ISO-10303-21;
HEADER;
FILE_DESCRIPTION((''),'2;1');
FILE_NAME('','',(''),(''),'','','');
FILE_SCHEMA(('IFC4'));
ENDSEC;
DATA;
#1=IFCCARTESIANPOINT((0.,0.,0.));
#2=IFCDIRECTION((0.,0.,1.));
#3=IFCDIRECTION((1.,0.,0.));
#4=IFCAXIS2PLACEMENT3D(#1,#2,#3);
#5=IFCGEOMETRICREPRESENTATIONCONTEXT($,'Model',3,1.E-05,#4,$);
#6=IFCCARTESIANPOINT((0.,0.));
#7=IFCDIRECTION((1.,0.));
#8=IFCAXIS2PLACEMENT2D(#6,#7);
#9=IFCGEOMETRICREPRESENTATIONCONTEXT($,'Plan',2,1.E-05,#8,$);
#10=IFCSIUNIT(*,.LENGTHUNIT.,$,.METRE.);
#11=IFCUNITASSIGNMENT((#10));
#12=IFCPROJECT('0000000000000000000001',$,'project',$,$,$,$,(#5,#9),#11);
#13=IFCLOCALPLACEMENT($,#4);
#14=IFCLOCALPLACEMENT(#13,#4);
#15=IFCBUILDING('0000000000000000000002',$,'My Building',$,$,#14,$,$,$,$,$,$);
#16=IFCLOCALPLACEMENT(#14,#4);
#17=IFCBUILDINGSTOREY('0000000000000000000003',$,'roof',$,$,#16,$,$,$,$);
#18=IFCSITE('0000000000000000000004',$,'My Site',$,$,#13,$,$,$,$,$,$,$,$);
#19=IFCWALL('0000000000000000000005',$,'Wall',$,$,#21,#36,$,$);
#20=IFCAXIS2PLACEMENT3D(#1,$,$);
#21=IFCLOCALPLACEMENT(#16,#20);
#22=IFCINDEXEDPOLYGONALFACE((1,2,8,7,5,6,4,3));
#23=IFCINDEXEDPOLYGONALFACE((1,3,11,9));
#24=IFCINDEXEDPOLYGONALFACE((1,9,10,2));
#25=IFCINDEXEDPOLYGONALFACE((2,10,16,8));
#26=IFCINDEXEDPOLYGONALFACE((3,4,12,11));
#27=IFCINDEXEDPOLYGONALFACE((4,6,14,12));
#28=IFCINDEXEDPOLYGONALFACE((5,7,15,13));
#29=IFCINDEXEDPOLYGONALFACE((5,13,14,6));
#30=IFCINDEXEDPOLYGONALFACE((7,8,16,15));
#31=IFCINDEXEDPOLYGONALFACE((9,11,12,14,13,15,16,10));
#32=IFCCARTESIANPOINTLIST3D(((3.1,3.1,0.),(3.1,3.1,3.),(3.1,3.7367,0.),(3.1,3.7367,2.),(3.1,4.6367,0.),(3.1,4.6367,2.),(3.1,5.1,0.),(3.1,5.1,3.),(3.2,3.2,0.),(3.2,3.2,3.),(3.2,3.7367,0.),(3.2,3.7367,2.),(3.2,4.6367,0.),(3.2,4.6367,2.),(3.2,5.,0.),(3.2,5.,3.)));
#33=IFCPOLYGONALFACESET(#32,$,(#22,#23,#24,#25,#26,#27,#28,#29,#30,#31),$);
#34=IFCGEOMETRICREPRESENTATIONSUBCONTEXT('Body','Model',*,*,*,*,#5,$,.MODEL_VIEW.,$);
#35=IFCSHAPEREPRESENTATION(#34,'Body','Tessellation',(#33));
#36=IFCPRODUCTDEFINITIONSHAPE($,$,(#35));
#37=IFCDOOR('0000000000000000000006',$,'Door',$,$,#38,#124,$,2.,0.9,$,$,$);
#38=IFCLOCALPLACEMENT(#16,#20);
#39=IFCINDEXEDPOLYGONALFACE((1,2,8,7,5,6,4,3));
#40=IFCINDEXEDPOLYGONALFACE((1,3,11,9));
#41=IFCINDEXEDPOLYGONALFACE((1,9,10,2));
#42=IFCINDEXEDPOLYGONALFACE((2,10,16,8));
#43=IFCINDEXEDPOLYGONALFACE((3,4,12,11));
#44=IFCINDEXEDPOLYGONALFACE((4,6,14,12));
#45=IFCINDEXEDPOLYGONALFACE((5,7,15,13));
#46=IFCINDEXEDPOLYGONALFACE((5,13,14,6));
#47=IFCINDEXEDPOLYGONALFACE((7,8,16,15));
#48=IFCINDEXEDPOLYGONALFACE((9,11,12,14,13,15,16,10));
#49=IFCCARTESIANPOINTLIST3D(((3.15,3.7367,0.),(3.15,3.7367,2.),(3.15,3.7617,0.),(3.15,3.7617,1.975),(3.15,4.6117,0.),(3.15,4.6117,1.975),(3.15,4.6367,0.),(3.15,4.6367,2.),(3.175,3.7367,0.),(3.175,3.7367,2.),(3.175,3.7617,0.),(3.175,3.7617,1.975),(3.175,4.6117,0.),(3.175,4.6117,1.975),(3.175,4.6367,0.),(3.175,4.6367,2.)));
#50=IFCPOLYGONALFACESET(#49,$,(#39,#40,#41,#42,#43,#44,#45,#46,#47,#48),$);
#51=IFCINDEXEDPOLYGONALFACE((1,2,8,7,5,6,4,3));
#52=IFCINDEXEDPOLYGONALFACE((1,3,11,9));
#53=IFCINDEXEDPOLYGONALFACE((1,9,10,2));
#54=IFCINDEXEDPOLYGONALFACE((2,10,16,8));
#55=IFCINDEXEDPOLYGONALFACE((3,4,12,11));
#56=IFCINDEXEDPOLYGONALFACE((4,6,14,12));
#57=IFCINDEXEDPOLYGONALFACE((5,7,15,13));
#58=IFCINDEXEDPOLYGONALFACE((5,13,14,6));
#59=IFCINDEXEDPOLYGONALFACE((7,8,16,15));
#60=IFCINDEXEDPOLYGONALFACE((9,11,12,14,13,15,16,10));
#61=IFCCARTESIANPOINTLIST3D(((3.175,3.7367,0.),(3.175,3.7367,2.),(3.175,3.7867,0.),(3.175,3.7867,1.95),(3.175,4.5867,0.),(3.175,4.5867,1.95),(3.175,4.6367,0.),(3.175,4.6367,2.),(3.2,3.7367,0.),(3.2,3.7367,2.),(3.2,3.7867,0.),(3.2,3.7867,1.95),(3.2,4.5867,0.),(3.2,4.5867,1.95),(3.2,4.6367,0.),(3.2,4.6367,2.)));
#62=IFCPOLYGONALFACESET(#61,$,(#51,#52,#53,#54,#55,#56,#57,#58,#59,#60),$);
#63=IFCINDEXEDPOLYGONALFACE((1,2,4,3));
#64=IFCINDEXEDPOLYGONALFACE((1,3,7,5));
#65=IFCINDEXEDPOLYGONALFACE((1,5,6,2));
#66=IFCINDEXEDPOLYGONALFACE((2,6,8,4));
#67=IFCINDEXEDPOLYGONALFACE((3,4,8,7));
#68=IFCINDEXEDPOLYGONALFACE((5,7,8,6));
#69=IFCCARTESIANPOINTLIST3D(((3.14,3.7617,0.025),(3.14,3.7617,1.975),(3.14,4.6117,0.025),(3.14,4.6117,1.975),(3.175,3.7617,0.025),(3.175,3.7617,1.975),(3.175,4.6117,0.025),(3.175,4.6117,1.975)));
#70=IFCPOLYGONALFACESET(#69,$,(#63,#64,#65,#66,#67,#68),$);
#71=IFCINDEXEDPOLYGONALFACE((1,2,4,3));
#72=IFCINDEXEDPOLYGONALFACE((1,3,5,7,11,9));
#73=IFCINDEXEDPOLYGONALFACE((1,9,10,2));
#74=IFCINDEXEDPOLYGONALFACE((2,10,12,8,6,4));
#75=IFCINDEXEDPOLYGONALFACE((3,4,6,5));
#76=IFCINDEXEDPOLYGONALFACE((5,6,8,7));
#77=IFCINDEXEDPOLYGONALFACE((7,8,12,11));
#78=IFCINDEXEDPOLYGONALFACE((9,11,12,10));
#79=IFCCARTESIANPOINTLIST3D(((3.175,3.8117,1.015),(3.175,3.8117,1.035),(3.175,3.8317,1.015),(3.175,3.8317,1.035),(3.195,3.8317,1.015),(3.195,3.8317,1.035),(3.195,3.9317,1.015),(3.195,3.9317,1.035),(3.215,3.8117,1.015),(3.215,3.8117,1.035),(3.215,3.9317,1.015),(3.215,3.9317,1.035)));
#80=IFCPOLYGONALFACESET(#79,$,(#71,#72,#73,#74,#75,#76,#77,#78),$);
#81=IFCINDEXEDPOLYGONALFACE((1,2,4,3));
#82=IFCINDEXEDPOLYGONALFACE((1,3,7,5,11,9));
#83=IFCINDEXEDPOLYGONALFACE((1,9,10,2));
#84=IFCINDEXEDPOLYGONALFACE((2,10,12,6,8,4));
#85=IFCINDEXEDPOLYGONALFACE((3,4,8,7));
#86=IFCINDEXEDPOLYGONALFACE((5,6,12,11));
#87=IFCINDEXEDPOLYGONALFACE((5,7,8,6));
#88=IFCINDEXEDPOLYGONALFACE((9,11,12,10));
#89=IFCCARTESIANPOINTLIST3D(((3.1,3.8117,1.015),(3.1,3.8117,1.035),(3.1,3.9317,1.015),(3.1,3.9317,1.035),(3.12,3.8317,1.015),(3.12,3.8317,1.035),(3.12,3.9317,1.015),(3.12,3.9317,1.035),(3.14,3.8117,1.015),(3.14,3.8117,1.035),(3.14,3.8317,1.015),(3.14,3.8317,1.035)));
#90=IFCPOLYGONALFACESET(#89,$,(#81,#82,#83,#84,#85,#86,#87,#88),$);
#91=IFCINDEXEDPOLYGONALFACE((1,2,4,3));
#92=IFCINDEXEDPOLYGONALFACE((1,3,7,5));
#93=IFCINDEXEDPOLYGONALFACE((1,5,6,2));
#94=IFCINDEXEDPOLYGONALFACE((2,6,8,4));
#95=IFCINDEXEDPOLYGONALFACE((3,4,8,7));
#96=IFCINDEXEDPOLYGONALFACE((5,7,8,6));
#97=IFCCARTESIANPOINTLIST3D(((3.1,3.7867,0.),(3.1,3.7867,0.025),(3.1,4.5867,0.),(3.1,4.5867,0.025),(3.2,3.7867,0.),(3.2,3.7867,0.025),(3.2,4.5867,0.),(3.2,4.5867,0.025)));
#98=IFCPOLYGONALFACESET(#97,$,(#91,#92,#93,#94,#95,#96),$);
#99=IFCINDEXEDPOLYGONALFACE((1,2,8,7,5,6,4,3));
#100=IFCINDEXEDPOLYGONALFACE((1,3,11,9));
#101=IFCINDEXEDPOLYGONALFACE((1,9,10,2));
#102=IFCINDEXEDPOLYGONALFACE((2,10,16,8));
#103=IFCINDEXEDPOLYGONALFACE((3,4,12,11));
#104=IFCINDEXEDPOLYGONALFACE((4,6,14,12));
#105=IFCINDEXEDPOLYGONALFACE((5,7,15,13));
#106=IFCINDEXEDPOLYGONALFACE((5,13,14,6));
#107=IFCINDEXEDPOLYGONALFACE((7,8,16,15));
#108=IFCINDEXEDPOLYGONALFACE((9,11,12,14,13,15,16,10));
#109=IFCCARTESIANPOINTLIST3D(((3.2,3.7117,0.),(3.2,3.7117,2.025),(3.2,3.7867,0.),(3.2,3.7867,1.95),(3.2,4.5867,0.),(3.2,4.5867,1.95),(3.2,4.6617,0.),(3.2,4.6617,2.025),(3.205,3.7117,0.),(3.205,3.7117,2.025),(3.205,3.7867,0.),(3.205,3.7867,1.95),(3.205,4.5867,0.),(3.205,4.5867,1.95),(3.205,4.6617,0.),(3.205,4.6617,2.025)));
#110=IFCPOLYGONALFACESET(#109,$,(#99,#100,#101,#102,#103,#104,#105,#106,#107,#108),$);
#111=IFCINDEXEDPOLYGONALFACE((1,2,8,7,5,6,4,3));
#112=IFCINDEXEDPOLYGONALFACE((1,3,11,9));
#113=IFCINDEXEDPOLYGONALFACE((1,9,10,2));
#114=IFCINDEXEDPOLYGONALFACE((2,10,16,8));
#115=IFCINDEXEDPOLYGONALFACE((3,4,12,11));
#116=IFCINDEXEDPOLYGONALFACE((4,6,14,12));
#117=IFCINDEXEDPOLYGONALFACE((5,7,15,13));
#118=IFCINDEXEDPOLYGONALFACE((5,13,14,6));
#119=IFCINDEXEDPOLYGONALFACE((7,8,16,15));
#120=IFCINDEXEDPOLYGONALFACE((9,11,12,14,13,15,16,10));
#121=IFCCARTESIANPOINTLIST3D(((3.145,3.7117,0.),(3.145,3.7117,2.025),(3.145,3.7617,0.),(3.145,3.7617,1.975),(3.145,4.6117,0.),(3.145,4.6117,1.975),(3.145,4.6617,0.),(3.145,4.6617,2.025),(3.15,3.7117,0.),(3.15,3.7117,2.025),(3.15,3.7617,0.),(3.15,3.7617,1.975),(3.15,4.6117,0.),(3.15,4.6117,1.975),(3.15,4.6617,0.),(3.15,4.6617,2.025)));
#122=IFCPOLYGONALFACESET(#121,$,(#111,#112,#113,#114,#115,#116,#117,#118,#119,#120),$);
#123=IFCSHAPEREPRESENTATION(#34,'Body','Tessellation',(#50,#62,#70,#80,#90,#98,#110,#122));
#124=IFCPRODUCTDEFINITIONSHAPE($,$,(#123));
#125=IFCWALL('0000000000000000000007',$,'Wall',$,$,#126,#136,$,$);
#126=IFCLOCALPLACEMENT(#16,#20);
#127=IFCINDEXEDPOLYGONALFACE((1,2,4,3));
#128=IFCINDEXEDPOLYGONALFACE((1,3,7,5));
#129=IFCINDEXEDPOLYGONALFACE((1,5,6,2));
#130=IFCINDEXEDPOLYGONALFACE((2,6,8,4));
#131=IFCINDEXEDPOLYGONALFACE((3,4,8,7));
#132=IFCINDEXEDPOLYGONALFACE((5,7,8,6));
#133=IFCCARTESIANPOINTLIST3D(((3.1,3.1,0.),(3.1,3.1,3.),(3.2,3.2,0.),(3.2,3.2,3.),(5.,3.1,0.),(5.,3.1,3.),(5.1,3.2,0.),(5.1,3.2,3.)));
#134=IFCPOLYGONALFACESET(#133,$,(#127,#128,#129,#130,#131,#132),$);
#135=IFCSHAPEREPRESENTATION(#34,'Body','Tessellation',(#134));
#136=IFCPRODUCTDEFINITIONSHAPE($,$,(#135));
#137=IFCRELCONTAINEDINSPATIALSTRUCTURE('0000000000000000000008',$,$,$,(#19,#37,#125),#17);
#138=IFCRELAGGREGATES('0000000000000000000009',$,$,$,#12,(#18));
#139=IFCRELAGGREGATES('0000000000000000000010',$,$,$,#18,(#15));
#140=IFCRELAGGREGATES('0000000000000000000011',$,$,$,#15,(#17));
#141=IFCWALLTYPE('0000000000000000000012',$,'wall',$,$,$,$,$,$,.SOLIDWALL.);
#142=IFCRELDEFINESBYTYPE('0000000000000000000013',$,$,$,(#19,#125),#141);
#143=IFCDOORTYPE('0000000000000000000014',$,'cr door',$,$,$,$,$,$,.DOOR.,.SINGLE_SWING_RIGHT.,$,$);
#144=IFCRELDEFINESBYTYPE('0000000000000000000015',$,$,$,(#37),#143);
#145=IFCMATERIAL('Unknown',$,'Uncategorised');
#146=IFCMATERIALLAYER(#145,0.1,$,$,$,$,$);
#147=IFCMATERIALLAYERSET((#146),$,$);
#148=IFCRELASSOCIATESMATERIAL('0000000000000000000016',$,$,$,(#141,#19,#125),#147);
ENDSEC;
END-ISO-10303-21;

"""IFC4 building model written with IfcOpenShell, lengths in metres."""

from ifc_helpers import new_model, entity, si_unit, frame, origin_with_axes, origin_2d_with_axis, place, context, subcontext, project, spatial, line, indexed_curve, outline, extrude, shape, source, transform, mapped, material, layer, layer_set, layer_usage, type_object, type_shapes, element, fill, save


model = new_model("IFC4")

# Units and contexts
model_context = context("Model", 3, precision=1e-05, world=origin_with_axes())
plan_context = context("Plan", 2, precision=1e-05, world=origin_2d_with_axis())
body_context_1 = subcontext(model_context, "Body", "Model", "MODEL_VIEW")
body_context_2 = subcontext(plan_context, "Body", "Plan", "PLAN_VIEW")
ifc_project = project(units=[si_unit("LENGTHUNIT", "METRE")], contexts=[model_context, plan_context])

# Site, building, storey
site_placement = place(None, origin_with_axes())
site = spatial("IfcSite", under=ifc_project, at=site_placement, Name="My Site")
building_placement = place(site_placement, origin_with_axes())
building = spatial("IfcBuilding", under=site, at=building_placement, Name="My Building")
storey_placement = place(building_placement, origin_with_axes())
storey = spatial("IfcBuildingStorey", under=building, at=storey_placement, Name="roof")

# Shared definitions
ifc_material = material(Name="Unknown", Category="Uncategorised")

# Wall, opening, door
ifc_layer_1 = layer(ifc_material, 0.1)
ifc_layer_set_1 = layer_set([ifc_layer_1])
ifc_layer_usage_1 = layer_usage(ifc_layer_set_1, "AXIS2", "POSITIVE", 0.0)
wall_type = type_object("IfcWallType", Name="wall", PredefinedType="SOLIDWALL", material=ifc_layer_set_1)
wall_1_placement = place(storey_placement, frame((3.1, 5.1, 0.0), z_axis=(0.0, 0.0, 1.0), x_axis=(0.0, -1.0, 0.0)))
wall_1 = element("IfcWall", 1, at=wall_1_placement, inside=storey, type_object=wall_type, material=ifc_layer_usage_1, Name="Wall", context=body_context_1, shape_type="SweptSolid", body=[
    extrude(outline(indexed_curve([(0.0, 0.0), (0.1, 0.1), (1.9, 0.1), (2.0, 0.0)], segments=[line(1, 2, 3, 4, 1)])), origin_with_axes(), (0.0, 0.0, 1.0), 3.0),
])
shared_shape_1 = source(origin_with_axes(), body_context_1, "Body", "SweptSolid", [
    extrude(outline(indexed_curve([(0.0, 0.0), (0.9, 0.0), (0.9, 2.0), (0.0, 2.0)], segments=[line(1, 2, 3, 4, 1)])), frame((0.0, -0.6, 0.0), z_axis=(0.0, -1.0, 0.0), x_axis=(1.0, 0.0, 0.0)), (0.0, 0.0, -1.0), 1.2),
])
opening_placement = place(wall_1_placement, frame((1.3633, 0.1, 0.0), z_axis=(0.0, 0.0, 1.0), x_axis=(-1.0, 0.0, 0.0)))
opening = element("IfcOpeningElement", 2, at=opening_placement, cuts=wall_1, PredefinedType="OPENING", context=body_context_1, shape_type="MappedRepresentation", body=[
    mapped(shared_shape_1, transform((0.0, 0.0, 0.0), x_axis=(1.0, 0.0, 0.0), y_axis=(0.0, 1.0, 0.0), z_axis=(0.0, 0.0, 1.0), scale=1.0)),
])
door_type = type_object("IfcDoorType", Name="cr door", OperationType="SINGLE_SWING_RIGHT", PredefinedType="DOOR")
shared_shape_2 = source(origin_with_axes(), body_context_1, "Body", "SweptSolid", [
    extrude(outline(indexed_curve([(0.0, 0.0), (0.0, 2.0), (0.9, 2.0), (0.9, 0.0), (0.875, 0.0), (0.875, 1.975), (0.025, 1.975), (0.025, 0.0)], segments=[line(1, 2, 3, 4, 5, 6, 7, 8, 1)])), frame((0.0, 0.025, 0.0), z_axis=(0.0, -1.0, 0.0), x_axis=(1.0, 0.0, 0.0)), (0.0, 0.0, -1.0), 0.025),
    extrude(outline(indexed_curve([(0.0, 0.0), (0.0, 2.0), (0.9, 2.0), (0.9, 0.0), (0.85, 0.0), (0.85, 1.95), (0.05, 1.95), (0.05, 0.0)], segments=[line(1, 2, 3, 4, 5, 6, 7, 8, 1)])), frame((0.0, 0.0, 0.0), z_axis=(0.0, -1.0, 0.0), x_axis=(1.0, 0.0, 0.0)), (0.0, 0.0, -1.0), 0.025),
    extrude(outline(indexed_curve([(0.0, 0.0), (0.85, 0.0), (0.85, 0.035), (0.0, 0.035)], segments=[line(1, 2, 3, 4, 1)])), frame((0.025, 0.025, 0.025), z_axis=(0.0, 0.0, 1.0), x_axis=(1.0, 0.0, 0.0)), (0.0, 0.0, 1.0), 1.95),
    extrude(outline(indexed_curve([(0.0, 0.0), (0.0, -0.04), (0.12, -0.04), (0.12, -0.02), (0.02, -0.02), (0.02, 0.0)], segments=[line(1, 2, 3, 4, 5, 6, 1)])), frame((0.075, 0.025, 1.015), z_axis=(0.0, 0.0, 1.0), x_axis=(1.0, 0.0, 0.0)), (0.0, 0.0, 1.0), 0.02),
    extrude(outline(indexed_curve([(0.0, 0.0), (0.0, 0.04), (0.12, 0.04), (0.12, 0.02), (0.02, 0.02), (0.02, 0.0)], segments=[line(1, 2, 3, 4, 5, 6, 1)])), frame((0.075, 0.06, 1.015), z_axis=(0.0, 0.0, 1.0), x_axis=(1.0, 0.0, 0.0)), (0.0, 0.0, 1.0), 0.02),
    extrude(outline(indexed_curve([(0.0, 0.0), (0.8, 0.0), (0.8, 0.1), (0.0, 0.1)], segments=[line(1, 2, 3, 4, 1)])), frame((0.05, 0.0, 0.0), z_axis=(0.0, 0.0, 1.0), x_axis=(1.0, 0.0, 0.0)), (0.0, 0.0, 1.0), 0.025),
    extrude(outline(indexed_curve([(0.0, 0.0), (0.0, 2.025), (0.95, 2.025), (0.95, 0.0), (0.875, 0.0), (0.875, 1.95), (0.075, 1.95), (0.075, 0.0)], segments=[line(1, 2, 3, 4, 5, 6, 7, 8, 1)])), frame((-0.025, -0.005, 0.0), z_axis=(0.0, -1.0, 0.0), x_axis=(1.0, 0.0, 0.0)), (0.0, 0.0, -1.0), 0.005),
    extrude(outline(indexed_curve([(0.0, 0.0), (0.0, 2.025), (0.95, 2.025), (0.95, 0.0), (0.9, 0.0), (0.9, 1.975), (0.05, 1.975), (0.05, 0.0)], segments=[line(1, 2, 3, 4, 5, 6, 7, 8, 1)])), frame((-0.025, 0.05, 0.0), z_axis=(0.0, -1.0, 0.0), x_axis=(1.0, 0.0, 0.0)), (0.0, 0.0, -1.0), 0.005),
])
shared_shape_3 = source(origin_with_axes(), body_context_2, "Body", "Curve2D", [
    entity("IfcIndexedPolyCurve", entity("IfcCartesianPointList2D", [[0.0, 0.0], [0.0, 0.05], [0.025, 0.05], [0.025, 0.025], [0.05, 0.025], [0.05, 0.0]]), [entity("IfcLineIndex", [1, 2, 3, 4, 5, 6, 1])]),
    entity("IfcIndexedPolyCurve", entity("IfcCartesianPointList2D", [[0.9, 0.0], [0.9, 0.05], [0.875, 0.05], [0.875, 0.025], [0.85, 0.025], [0.85, 0.0]]), [entity("IfcLineIndex", [1, 2, 3, 4, 5, 6, 1])]),
    entity("IfcTrimmedCurve", entity("IfcEllipse", entity("IfcAxis2Placement2D", entity("IfcCartesianPoint", [0.84, 0.05]), entity("IfcDirection", [1.0, 0.0])), 0.815, 0.85), [entity("IfcCartesianPoint", [0.84, 0.9])], [entity("IfcCartesianPoint", [0.025, 0.05])], True, "CARTESIAN"),
    entity("IfcIndexedPolyCurve", entity("IfcCartesianPointList2D", [[0.875, 0.05], [0.84, 0.05], [0.84, 0.9], [0.875, 0.9]]), [entity("IfcLineIndex", [1, 2, 3, 4, 1])]),
])
type_shapes(door_type, [shared_shape_2, shared_shape_3])
door_placement = place(opening_placement, frame((0.0, 0.0, 0.0), z_axis=(0.0, 0.0, 1.0), x_axis=(1.0, 0.0, 0.0)))
door = element("IfcDoor", 3, at=door_placement, inside=storey, type_object=door_type, Name="Door", OverallHeight=2.0, OverallWidth=0.9, shapes=[
    shape(body_context_1, "Body", "MappedRepresentation", [mapped(shared_shape_2, transform((0.0, 0.0, 0.0), x_axis=(1.0, 0.0, 0.0), y_axis=(0.0, 1.0, 0.0), z_axis=(0.0, 0.0, 1.0), scale=1.0))]),
    shape(body_context_2, "Body", "MappedRepresentation", [mapped(shared_shape_3, transform((0.0, 0.0, 0.0), x_axis=(1.0, 0.0, 0.0), y_axis=(0.0, 1.0, 0.0), z_axis=(0.0, 0.0, 1.0), scale=1.0))]),
])
fill(opening, door)

# Wall
ifc_layer_usage_2 = layer_usage(ifc_layer_set_1, "AXIS2", "POSITIVE", 0.0)
wall_2_placement = place(storey_placement, frame((3.1, 3.1, 0.0), z_axis=(0.0, 0.0, 1.0), x_axis=(1.0, 0.0, 0.0)))
element("IfcWall", 4, at=wall_2_placement, inside=storey, type_object=wall_type, material=ifc_layer_usage_2, Name="Wall", context=body_context_1, shape_type="SweptSolid", body=[
    extrude(outline(indexed_curve([(0.0, 0.0), (0.1, 0.1), (2.0, 0.1), (1.9, 0.0)], segments=[line(1, 2, 3, 4, 1)])), origin_with_axes(), (0.0, 0.0, 1.0), 3.0),
])

save(model, "model.ifc")
